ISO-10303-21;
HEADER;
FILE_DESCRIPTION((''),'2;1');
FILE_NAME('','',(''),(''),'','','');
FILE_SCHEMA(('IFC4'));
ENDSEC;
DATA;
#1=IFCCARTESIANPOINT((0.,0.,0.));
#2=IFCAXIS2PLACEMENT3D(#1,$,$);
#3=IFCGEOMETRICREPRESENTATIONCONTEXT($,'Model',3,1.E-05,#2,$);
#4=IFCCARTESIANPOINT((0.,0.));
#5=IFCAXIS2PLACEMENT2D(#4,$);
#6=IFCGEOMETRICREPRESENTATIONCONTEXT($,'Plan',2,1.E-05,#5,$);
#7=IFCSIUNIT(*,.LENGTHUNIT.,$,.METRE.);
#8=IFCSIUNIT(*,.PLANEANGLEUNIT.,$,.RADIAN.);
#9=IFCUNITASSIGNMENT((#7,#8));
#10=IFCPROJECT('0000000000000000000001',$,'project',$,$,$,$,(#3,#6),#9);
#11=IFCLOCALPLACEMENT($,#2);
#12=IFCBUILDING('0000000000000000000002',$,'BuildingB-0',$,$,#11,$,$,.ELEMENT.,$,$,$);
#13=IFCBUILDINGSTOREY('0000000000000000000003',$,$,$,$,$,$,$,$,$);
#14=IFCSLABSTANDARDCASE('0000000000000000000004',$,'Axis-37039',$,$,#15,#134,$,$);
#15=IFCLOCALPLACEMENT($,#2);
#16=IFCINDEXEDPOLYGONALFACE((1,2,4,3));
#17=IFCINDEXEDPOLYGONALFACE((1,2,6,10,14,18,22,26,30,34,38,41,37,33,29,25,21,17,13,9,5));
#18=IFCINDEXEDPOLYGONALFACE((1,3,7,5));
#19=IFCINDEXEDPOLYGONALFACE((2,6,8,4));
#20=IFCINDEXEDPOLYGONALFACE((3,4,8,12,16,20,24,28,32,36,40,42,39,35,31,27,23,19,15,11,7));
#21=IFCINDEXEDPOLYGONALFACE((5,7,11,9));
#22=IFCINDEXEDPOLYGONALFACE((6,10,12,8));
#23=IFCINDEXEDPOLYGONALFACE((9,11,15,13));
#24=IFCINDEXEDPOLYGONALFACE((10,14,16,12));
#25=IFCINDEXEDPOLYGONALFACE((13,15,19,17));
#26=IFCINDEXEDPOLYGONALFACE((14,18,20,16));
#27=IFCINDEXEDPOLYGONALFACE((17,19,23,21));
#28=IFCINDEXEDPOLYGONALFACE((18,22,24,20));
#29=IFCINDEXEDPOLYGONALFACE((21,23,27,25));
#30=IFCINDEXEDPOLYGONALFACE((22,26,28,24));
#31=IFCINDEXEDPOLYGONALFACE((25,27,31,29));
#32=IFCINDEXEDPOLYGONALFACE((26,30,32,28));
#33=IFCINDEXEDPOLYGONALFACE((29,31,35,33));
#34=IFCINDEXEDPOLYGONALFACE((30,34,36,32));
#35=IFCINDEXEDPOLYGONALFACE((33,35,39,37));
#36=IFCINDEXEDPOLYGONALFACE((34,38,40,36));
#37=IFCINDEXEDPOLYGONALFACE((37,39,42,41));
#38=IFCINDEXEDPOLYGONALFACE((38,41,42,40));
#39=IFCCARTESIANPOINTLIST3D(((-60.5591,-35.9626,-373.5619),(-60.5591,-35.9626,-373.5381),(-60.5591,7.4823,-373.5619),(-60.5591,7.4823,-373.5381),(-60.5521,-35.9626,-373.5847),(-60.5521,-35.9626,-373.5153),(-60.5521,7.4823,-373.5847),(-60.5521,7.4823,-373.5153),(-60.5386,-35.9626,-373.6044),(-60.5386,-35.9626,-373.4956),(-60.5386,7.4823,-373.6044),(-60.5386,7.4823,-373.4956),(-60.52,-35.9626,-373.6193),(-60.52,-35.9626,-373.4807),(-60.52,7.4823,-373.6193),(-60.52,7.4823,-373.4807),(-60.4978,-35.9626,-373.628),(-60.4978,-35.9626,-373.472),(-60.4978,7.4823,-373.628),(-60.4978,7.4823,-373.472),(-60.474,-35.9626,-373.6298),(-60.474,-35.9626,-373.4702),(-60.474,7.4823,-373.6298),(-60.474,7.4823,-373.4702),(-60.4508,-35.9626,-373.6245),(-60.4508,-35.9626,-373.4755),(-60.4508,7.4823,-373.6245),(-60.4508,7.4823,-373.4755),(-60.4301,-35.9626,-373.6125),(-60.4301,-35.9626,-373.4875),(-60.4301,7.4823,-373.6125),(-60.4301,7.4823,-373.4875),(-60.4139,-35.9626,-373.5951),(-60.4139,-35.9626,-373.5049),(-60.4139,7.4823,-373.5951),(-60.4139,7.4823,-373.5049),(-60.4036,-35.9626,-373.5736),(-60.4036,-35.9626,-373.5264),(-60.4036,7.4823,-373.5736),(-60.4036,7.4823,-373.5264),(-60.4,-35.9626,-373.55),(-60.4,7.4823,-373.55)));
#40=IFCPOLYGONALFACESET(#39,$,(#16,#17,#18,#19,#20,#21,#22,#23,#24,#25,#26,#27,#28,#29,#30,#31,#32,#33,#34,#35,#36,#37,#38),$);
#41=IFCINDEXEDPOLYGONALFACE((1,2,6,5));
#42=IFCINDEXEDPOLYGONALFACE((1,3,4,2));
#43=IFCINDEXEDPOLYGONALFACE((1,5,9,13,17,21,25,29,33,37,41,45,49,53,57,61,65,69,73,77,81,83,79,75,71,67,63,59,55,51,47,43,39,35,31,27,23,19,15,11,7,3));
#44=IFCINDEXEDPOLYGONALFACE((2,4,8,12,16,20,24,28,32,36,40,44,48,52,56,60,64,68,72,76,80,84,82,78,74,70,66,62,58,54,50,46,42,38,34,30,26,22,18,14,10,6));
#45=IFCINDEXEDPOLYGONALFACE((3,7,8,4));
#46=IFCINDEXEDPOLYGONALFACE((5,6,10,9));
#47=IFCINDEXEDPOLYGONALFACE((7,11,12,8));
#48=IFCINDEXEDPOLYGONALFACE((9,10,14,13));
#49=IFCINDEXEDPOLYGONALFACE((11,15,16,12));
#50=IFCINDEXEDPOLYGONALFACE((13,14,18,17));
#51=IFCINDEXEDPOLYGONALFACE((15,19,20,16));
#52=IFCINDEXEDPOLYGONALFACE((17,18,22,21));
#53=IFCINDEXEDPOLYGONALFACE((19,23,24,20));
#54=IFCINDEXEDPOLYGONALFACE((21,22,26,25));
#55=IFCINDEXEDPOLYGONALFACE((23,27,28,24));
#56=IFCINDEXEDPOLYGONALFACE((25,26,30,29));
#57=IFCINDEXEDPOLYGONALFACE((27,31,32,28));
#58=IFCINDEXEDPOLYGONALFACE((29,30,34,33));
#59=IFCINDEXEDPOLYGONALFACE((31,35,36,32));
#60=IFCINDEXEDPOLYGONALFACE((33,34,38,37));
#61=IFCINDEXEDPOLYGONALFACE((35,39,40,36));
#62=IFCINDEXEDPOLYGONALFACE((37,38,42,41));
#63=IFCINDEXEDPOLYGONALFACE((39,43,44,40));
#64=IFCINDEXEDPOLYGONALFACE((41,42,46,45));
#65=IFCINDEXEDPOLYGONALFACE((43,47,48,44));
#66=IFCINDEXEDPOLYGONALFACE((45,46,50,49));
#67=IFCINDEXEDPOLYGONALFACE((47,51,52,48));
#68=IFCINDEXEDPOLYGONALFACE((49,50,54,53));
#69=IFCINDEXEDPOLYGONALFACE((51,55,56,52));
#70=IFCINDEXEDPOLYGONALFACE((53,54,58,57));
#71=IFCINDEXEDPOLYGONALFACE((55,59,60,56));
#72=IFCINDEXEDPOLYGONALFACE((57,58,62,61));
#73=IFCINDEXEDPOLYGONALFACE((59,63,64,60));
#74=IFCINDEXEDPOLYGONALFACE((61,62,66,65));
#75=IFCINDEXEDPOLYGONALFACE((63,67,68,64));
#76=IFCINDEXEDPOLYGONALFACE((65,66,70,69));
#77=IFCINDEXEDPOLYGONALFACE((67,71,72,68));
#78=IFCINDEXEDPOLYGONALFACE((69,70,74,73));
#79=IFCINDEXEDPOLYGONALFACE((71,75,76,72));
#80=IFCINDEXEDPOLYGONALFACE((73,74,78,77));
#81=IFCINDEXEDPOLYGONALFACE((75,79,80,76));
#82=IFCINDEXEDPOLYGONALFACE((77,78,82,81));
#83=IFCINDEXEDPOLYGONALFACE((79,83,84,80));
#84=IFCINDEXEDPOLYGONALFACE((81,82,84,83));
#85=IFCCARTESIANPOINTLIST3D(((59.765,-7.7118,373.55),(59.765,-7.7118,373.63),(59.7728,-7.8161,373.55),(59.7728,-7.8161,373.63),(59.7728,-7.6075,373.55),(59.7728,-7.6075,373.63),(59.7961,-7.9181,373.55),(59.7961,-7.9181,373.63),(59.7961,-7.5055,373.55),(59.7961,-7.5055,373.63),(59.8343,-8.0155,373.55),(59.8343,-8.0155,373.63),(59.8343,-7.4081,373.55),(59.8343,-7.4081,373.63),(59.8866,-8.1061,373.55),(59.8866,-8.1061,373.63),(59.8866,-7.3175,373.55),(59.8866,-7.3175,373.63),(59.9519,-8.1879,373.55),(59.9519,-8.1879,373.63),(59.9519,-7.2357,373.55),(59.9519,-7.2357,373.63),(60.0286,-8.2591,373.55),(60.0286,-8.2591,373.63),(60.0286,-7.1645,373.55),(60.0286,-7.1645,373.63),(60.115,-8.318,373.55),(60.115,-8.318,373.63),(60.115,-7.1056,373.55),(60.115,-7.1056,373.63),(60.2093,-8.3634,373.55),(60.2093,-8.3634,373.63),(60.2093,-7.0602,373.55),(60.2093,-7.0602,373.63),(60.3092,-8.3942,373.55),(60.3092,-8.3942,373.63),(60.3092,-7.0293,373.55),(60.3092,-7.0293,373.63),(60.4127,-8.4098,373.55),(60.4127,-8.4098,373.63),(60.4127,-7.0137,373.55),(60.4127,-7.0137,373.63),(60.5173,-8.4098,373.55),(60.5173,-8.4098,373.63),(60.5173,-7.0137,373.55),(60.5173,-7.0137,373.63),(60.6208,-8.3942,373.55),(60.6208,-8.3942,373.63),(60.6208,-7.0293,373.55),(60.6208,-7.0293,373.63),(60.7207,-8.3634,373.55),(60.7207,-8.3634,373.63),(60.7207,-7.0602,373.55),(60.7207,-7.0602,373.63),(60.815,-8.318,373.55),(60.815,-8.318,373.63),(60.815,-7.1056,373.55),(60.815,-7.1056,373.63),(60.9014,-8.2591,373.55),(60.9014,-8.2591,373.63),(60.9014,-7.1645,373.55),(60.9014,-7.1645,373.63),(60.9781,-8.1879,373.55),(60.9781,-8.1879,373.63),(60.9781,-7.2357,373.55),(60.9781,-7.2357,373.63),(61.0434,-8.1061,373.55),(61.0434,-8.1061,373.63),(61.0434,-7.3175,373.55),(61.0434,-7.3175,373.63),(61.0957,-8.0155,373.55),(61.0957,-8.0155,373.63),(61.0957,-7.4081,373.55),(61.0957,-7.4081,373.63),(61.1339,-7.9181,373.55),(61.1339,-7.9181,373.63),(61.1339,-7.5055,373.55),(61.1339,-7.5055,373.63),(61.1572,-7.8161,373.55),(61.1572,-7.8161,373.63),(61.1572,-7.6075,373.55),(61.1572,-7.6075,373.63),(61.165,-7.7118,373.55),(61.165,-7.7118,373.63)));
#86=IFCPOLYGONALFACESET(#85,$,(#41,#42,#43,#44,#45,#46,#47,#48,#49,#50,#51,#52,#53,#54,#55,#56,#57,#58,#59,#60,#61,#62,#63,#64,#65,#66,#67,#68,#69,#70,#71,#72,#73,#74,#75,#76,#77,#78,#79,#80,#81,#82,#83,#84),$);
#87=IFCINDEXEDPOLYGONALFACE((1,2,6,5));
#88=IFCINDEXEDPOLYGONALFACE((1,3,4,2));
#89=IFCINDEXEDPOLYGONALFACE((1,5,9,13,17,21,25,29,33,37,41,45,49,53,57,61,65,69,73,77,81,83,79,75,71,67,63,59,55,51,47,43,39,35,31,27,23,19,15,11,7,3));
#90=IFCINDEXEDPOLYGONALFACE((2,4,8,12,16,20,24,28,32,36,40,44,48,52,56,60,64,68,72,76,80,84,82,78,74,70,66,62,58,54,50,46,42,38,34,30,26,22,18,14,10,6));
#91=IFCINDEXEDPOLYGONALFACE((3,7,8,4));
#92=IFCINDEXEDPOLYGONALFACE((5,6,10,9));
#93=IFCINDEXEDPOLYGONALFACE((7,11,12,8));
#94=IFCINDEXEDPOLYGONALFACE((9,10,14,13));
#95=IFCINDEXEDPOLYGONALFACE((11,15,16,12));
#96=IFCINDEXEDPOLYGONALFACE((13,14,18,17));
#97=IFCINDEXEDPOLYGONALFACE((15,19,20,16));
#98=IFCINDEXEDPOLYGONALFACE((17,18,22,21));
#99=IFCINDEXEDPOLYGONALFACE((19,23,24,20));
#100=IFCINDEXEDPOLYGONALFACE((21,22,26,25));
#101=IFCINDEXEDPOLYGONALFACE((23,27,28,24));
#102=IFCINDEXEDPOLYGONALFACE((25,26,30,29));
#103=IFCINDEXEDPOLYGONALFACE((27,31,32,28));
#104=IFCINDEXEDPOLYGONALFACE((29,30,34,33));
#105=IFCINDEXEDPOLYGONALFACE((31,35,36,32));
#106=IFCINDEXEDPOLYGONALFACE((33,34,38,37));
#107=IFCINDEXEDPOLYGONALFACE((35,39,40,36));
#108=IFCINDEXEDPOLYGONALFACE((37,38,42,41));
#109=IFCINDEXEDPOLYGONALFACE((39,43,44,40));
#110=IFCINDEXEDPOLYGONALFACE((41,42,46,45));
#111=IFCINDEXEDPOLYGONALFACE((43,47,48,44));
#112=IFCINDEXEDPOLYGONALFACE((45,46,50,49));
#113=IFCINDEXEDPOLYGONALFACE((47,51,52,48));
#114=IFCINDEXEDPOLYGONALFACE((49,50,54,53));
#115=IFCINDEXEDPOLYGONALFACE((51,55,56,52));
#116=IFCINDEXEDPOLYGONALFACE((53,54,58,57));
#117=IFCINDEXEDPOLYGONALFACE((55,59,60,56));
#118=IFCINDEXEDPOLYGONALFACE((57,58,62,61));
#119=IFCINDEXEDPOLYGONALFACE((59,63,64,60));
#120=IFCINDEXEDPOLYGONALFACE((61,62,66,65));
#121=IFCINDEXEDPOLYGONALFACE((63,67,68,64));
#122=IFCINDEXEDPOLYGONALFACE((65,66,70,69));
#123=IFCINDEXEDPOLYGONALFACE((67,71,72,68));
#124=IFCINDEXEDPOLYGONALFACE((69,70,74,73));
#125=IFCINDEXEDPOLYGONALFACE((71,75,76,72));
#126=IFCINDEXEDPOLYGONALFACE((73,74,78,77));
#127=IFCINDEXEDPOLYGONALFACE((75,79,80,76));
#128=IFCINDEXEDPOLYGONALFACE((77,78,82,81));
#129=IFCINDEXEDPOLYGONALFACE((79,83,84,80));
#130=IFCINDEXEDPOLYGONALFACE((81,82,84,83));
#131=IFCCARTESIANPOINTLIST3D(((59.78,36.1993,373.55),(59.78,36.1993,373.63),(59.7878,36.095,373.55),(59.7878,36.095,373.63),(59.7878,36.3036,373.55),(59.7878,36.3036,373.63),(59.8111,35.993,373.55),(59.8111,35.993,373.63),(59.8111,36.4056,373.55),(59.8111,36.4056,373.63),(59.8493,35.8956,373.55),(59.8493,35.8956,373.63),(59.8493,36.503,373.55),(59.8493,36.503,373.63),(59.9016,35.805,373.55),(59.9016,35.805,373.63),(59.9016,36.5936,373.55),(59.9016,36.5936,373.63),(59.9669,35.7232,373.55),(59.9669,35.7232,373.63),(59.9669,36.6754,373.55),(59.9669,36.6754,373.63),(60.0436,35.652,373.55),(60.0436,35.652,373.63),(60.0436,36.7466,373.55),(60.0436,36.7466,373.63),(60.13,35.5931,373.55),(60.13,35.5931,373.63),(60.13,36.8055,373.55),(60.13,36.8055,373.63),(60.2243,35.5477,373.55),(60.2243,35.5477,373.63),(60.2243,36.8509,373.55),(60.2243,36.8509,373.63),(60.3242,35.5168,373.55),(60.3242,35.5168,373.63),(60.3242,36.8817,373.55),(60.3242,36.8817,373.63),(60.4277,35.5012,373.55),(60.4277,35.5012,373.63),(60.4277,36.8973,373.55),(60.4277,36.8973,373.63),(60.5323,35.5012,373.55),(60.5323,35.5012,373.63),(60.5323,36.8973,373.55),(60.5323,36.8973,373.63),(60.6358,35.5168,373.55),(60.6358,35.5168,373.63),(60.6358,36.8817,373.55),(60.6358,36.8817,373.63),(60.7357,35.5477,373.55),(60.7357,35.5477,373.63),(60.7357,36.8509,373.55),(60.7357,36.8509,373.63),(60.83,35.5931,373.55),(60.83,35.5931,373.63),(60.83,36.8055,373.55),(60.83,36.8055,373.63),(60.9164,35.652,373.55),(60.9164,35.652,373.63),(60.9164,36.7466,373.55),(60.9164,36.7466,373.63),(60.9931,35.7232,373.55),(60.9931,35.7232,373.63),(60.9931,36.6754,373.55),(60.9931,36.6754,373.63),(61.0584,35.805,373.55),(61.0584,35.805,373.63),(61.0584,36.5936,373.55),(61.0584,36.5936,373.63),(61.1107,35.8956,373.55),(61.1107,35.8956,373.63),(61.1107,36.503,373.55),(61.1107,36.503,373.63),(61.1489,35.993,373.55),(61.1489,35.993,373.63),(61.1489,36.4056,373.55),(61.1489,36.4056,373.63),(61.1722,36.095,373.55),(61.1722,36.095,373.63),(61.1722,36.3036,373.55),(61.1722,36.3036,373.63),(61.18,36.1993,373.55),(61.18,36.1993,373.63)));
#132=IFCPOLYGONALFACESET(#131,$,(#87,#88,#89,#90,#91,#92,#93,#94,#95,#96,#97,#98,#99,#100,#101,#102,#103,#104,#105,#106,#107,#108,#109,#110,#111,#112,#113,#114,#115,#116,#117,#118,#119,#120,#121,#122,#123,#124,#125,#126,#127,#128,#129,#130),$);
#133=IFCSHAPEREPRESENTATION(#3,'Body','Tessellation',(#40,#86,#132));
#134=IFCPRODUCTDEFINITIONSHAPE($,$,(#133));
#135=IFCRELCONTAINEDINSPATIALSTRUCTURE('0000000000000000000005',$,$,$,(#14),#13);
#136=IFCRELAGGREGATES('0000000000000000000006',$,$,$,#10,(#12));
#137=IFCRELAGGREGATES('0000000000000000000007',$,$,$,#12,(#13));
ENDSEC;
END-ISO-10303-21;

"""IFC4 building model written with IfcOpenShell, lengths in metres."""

from ifc_helpers import new_model, entity, si_unit, frame, origin, origin_2d, place, context, project, spatial, circle, extrude, element, save


model = new_model("IFC4")

# Units and contexts
model_context = context("Model", 3, precision=1e-05, world=origin())
plan_context = context("Plan", 2, precision=1e-05, world=origin_2d())
ifc_project = project(units=[si_unit("LENGTHUNIT", "METRE"), si_unit("PLANEANGLEUNIT", "RADIAN")], contexts=[model_context, plan_context])

# Building, storey
building_placement = place(None, origin())
building = spatial("IfcBuilding", under=ifc_project, at=building_placement, Name="BuildingB-0", CompositionType="ELEMENT")
storey = spatial("IfcBuildingStorey", under=building)

# Slab
element("IfcSlabStandardCase", 1, inside=storey, Name="Axis-37039", context=model_context, shape_type="AdvancedSweptSolid", body=[
    entity("IfcSurfaceCurveSweptAreaSolid", entity("IfcCircleProfileDef", "AREA", None, None, 0.08), None, entity("IfcPolyline", [entity("IfcCartesianPoint", [60.48, -7.4823, 373.55]), entity("IfcCartesianPoint", [60.48, 35.9626, 373.55])]), None, None, entity("IfcPlane", entity("IfcAxis2Placement3D", entity("IfcCartesianPoint", [60.48, -7.4823, 373.55]), entity("IfcDirection", [0.0, 0.0, 1.0]), entity("IfcDirection", [1.0, 0.0, 0.0])))),
    extrude(circle(Radius=0.7), frame((60.465, -7.7118, 373.55)), (0.0, 0.0, 1.0), 0.08),
    extrude(circle(Radius=0.7), frame((60.48, 36.1993, 373.55)), (0.0, 0.0, 1.0), 0.08),
])

save(model, "model.ifc")
